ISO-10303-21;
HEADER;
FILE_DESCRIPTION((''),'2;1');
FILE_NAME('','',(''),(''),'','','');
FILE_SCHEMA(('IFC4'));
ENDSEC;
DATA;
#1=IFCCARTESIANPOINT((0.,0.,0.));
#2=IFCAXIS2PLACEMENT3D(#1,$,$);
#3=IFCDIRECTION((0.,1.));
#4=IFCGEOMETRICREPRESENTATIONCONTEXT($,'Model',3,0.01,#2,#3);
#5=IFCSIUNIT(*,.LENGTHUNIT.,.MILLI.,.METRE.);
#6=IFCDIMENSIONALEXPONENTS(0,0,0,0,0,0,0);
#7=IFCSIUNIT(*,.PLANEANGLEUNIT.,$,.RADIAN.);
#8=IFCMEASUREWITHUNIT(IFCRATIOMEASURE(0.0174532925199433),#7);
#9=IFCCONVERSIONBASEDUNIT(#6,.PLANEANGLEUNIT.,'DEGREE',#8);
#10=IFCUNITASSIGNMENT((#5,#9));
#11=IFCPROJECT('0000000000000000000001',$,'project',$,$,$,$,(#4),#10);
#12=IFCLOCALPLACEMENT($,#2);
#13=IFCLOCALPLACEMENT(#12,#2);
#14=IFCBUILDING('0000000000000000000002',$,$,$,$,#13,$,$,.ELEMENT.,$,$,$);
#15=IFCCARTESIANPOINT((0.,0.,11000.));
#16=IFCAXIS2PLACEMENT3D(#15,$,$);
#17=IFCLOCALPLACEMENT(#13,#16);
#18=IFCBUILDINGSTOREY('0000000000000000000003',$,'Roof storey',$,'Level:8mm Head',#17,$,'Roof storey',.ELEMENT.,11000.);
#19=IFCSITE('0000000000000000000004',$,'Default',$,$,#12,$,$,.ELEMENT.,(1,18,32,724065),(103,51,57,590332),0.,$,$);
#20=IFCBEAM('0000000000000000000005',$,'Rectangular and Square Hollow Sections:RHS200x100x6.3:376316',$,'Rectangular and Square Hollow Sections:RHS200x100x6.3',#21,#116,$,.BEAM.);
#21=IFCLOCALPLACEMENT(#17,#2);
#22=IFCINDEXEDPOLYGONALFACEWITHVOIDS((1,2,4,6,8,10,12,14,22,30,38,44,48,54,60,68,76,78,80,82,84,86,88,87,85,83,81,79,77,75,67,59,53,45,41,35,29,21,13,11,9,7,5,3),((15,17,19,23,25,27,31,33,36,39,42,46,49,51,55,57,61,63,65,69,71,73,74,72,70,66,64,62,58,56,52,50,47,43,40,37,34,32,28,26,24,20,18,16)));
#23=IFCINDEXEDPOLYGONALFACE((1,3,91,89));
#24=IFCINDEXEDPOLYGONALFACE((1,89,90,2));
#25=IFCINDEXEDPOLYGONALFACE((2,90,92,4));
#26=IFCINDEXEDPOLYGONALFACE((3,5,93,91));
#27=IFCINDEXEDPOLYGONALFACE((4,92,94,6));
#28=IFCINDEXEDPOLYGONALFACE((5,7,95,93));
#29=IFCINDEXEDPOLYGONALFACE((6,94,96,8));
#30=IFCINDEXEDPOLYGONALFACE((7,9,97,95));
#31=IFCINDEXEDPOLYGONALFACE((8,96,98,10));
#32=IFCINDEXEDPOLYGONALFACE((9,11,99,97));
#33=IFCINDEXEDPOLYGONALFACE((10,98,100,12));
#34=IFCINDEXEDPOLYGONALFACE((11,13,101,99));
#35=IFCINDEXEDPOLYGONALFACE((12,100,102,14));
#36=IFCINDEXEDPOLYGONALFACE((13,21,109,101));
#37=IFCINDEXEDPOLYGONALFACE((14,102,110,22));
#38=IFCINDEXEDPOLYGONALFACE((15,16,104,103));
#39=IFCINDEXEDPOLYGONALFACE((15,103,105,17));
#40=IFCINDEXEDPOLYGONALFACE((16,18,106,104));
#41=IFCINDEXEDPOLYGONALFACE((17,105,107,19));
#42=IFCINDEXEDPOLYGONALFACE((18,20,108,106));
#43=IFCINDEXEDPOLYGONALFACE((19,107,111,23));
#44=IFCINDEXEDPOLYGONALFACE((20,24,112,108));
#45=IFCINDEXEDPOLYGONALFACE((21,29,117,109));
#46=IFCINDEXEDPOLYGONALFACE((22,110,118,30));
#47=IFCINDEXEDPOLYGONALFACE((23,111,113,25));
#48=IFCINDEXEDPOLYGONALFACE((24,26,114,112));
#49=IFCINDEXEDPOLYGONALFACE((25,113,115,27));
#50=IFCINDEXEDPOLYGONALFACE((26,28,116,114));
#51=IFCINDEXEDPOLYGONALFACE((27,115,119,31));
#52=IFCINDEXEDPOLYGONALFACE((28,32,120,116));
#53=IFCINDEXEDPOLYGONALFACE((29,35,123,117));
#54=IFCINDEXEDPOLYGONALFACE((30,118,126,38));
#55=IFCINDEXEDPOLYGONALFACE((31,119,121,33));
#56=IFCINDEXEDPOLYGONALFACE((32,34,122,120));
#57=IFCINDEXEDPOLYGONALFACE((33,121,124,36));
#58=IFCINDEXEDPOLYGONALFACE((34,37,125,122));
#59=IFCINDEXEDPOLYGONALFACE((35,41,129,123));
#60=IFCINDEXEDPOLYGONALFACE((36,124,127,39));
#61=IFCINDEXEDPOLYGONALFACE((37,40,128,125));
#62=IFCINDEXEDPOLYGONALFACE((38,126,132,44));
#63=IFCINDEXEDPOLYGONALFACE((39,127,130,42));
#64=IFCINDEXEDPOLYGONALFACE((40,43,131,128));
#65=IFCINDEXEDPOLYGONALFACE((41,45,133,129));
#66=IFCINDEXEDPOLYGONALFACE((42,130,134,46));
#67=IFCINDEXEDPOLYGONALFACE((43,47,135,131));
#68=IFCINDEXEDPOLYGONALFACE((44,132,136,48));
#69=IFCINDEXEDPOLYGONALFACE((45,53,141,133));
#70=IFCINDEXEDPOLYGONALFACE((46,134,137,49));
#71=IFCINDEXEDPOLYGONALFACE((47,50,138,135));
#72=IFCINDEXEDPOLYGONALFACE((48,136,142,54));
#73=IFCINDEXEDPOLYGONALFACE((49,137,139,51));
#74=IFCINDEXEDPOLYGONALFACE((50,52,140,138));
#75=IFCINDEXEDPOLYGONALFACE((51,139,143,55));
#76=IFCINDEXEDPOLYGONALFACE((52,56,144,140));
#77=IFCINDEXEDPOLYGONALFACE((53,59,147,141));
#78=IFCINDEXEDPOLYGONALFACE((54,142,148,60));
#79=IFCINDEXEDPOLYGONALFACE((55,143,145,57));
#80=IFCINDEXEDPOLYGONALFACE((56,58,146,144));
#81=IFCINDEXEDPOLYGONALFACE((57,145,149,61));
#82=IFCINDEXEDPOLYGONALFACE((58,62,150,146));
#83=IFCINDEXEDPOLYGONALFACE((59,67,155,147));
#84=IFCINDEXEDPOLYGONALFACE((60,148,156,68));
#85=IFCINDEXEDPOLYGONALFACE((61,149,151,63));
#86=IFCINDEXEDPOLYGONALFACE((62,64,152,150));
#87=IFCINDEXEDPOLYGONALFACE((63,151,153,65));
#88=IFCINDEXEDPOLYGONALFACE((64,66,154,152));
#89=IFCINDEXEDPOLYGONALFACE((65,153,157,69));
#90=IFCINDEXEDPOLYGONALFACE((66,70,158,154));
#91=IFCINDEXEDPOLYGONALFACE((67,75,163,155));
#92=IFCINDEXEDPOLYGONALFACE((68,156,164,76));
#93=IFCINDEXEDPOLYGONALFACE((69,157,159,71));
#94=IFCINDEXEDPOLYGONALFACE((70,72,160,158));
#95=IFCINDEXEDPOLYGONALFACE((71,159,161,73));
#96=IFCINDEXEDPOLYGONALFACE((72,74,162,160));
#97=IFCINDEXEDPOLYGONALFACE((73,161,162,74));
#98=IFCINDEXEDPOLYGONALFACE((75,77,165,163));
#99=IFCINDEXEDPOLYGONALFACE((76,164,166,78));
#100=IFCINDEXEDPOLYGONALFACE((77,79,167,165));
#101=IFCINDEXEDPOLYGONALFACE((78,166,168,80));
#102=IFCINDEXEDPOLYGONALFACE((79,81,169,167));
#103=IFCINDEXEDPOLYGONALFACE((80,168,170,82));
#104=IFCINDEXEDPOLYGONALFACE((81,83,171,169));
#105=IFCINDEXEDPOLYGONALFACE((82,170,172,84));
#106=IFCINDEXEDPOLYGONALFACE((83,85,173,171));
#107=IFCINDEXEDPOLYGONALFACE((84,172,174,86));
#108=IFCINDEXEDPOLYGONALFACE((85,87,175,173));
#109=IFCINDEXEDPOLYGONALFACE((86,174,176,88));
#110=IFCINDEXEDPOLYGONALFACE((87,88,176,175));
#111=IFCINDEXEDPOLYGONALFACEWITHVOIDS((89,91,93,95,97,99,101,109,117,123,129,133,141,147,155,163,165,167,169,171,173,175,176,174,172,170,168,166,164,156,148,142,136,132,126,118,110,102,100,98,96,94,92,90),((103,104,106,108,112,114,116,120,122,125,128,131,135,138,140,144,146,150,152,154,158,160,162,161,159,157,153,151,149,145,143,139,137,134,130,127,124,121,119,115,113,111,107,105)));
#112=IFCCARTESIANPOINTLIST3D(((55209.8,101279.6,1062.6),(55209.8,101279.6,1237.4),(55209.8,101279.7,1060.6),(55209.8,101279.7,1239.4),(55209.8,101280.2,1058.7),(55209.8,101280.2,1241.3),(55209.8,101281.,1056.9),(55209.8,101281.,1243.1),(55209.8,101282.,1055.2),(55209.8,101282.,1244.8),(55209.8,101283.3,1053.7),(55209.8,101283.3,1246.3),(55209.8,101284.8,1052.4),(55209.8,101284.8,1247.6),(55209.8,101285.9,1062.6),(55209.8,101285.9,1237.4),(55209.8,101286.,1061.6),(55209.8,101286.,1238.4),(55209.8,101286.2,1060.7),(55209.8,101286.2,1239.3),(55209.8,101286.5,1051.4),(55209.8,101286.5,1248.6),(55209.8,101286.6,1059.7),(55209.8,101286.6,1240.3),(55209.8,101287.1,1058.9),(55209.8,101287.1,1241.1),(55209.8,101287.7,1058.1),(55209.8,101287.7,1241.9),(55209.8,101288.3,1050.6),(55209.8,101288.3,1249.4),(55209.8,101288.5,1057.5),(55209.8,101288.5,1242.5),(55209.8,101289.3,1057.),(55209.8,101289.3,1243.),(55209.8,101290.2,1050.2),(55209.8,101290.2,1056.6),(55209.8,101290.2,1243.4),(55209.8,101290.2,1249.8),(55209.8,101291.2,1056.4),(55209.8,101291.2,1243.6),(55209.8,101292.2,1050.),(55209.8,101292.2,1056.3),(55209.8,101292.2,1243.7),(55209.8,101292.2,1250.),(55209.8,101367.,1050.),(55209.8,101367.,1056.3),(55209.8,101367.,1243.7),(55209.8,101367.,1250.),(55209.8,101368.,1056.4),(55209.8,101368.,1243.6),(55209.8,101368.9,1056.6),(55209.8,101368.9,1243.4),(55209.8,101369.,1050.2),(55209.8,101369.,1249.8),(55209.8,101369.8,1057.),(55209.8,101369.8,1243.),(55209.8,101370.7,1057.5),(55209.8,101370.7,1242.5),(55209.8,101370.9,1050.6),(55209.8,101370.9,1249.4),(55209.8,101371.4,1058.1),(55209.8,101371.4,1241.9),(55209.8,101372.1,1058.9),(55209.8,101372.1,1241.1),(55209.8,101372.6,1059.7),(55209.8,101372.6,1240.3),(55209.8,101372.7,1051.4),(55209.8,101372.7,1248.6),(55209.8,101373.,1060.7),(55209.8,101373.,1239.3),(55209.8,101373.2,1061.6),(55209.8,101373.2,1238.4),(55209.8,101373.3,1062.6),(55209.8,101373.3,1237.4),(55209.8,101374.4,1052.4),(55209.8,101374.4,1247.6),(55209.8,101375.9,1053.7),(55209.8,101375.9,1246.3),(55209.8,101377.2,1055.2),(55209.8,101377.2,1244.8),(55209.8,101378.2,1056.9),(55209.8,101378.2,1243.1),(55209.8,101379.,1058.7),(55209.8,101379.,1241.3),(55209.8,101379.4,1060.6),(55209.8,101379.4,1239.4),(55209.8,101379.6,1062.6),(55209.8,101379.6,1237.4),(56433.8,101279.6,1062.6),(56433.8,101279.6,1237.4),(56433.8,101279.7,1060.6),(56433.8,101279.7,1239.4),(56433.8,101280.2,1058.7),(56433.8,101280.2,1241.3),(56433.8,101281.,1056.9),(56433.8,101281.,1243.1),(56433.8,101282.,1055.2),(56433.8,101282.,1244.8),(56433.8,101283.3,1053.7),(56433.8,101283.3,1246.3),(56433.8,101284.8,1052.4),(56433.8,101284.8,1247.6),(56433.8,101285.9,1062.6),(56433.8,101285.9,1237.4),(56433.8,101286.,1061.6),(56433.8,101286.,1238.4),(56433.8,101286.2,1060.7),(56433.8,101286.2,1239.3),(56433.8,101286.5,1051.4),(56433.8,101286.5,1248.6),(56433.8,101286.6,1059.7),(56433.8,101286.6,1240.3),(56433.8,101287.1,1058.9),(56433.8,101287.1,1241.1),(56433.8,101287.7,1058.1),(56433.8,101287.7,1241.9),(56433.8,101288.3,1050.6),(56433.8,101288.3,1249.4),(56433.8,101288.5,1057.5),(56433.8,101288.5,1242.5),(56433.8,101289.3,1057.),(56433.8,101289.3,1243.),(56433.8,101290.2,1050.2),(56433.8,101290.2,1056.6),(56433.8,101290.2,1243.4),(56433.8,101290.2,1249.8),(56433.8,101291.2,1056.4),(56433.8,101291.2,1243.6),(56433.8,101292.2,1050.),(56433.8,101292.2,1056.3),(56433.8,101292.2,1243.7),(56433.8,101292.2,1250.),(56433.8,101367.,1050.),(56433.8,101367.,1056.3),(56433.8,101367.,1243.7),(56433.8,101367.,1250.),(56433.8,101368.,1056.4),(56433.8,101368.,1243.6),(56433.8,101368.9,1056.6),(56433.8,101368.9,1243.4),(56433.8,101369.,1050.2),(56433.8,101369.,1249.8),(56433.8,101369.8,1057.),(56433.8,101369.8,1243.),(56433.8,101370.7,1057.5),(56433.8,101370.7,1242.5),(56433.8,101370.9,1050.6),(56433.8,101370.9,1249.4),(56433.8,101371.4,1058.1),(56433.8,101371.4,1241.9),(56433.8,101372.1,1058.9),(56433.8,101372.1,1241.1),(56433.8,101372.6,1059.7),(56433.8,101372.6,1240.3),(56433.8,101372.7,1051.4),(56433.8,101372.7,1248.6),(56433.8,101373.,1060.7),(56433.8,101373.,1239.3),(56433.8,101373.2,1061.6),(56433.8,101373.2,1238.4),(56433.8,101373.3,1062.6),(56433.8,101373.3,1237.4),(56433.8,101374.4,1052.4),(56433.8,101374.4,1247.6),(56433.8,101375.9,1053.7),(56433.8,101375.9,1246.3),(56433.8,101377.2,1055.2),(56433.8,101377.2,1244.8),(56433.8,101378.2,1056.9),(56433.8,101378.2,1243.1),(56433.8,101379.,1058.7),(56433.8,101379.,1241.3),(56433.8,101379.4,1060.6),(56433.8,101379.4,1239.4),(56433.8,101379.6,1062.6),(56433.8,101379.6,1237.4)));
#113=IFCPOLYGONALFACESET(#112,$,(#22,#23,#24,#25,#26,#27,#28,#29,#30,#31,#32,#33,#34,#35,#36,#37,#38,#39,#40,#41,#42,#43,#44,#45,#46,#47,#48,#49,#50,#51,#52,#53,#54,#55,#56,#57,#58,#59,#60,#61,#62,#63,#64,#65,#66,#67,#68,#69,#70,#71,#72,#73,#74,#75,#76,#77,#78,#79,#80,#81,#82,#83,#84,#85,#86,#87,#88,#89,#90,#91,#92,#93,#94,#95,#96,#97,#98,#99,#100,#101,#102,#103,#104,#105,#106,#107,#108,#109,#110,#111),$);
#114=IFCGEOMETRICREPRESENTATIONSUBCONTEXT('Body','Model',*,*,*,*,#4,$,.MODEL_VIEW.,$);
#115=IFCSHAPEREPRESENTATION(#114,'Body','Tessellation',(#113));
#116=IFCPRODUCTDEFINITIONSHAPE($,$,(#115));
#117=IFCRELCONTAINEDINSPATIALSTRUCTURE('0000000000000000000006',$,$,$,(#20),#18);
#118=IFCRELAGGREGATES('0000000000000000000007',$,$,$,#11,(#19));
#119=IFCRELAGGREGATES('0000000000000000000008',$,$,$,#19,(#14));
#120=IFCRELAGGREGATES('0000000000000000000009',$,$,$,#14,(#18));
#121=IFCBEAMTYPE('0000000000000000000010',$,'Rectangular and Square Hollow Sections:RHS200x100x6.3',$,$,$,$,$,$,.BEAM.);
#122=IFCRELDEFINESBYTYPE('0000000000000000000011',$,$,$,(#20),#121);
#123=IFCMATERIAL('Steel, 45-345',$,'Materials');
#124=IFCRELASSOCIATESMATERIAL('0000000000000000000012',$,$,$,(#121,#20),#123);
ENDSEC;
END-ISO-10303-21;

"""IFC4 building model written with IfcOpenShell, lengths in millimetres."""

from ifc_helpers import new_model, entity, si_unit, converted_unit, direction, frame, origin, place, context, subcontext, project, spatial, indexed_curve, outline, extrude, source, transform, mapped, material, type_object, type_shapes, element, save


model = new_model("IFC4")

# Units and contexts
model_context = context("Model", 3, precision=0.01, world=origin(), true_north=direction((0.0, 1.0)))
body_context = subcontext(model_context, "Body", "Model", "MODEL_VIEW")
ifc_project = project(units=[si_unit("LENGTHUNIT", "METRE", prefix="MILLI"), converted_unit("PLANEANGLEUNIT", "DEGREE", entity("IfcRatioMeasure", 0.0174532925199433), si_unit("PLANEANGLEUNIT", "RADIAN"), dimensions=[0, 0, 0, 0, 0, 0, 0])], contexts=[model_context])

# Site, building, storey
site_placement = place(None, origin())
site = spatial("IfcSite", under=ifc_project, at=site_placement, Name="Default", CompositionType="ELEMENT", RefLatitude=(1, 18, 32, 724065), RefLongitude=(103, 51, 57, 590332), RefElevation=0.0)
building_placement = place(site_placement, origin())
building = spatial("IfcBuilding", under=site, at=building_placement, CompositionType="ELEMENT")
storey_placement = place(building_placement, frame((0.0, 0.0, 11000.0)))
storey = spatial("IfcBuildingStorey", under=building, at=storey_placement, Name="Roof storey", ObjectType="Level:8mm Head", LongName="Roof storey", CompositionType="ELEMENT", Elevation=11000.0)

# Shared definitions
ifc_material = material(Name="Steel, 45-345", Category="Materials")

# Beam
beam_type_1 = type_object("IfcBeamType", Name="Rectangular and Square Hollow Sections:RHS200x100x6.3", PredefinedType="BEAM", material=ifc_material)
shared_shape_1 = source(origin(), body_context, "Body", "SweptSolid", [
    extrude(outline(indexed_curve([(87.4, -50.0), (89.4, -49.8), (91.3, -49.4), (93.1, -48.6), (94.8, -47.6), (96.3, -46.3), (97.6, -44.8), (98.6, -43.1), (99.4, -41.3), (99.8, -39.4), (100.0, -37.4), (100.0, 37.4), (99.8, 39.4), (99.4, 41.3), (98.6, 43.1), (97.6, 44.8), (96.3, 46.3), (94.8, 47.6), (93.1, 48.6), (91.3, 49.4), (89.4, 49.8), (87.4, 50.0), (-87.4, 50.0), (-89.4, 49.8), (-91.3, 49.4), (-93.1, 48.6), (-94.8, 47.6), (-96.3, 46.3), (-97.6, 44.8), (-98.6, 43.1), (-99.4, 41.3), (-99.8, 39.4), (-100.0, 37.4), (-100.0, -37.4), (-99.8, -39.4), (-99.4, -41.3), (-98.6, -43.1), (-97.6, -44.8), (-96.3, -46.3), (-94.8, -47.6), (-93.1, -48.6), (-91.3, -49.4), (-89.4, -49.8), (-87.4, -50.0), (87.4, -50.0)], self_intersect=False), holes=[indexed_curve([(93.7, 37.4), (93.7, -37.4), (93.6, -38.4), (93.4, -39.3), (93.0, -40.3), (92.5, -41.1), (91.9, -41.9), (91.1, -42.5), (90.3, -43.0), (89.3, -43.4), (88.4, -43.6), (87.4, -43.7), (-87.4, -43.7), (-88.4, -43.6), (-89.3, -43.4), (-90.3, -43.0), (-91.1, -42.5), (-91.9, -41.9), (-92.5, -41.1), (-93.0, -40.3), (-93.4, -39.3), (-93.6, -38.4), (-93.7, -37.4), (-93.7, 37.4), (-93.6, 38.4), (-93.4, 39.3), (-93.0, 40.3), (-92.5, 41.1), (-91.9, 41.9), (-91.1, 42.5), (-90.3, 43.0), (-89.3, 43.4), (-88.4, 43.6), (-87.4, 43.7), (87.4, 43.7), (88.4, 43.6), (89.3, 43.4), (90.3, 43.0), (91.1, 42.5), (91.9, 41.9), (92.5, 41.1), (93.0, 40.3), (93.4, 39.3), (93.6, 38.4), (93.7, 37.4)], self_intersect=False)]), frame((-612.0, 0.0, 0.0), z_axis=(1.0, 0.0, 0.0), x_axis=(0.0, 0.0, 1.0)), (0.0, 0.0, 1.0), 1224.0),
])
type_shapes(beam_type_1, [shared_shape_1])
beam_1_placement = place(storey_placement, frame((55821.8, 101329.6, 1150.0)))
element("IfcBeam", 1, at=beam_1_placement, inside=storey, type_object=beam_type_1, material=ifc_material, Name="Rectangular and Square Hollow Sections:RHS200x100x6.3:376316", ObjectType="Rectangular and Square Hollow Sections:RHS200x100x6.3", PredefinedType="BEAM", context=body_context, shape_type="MappedRepresentation", body=[
    mapped(shared_shape_1, transform((0.0, 0.0, 0.0), scale=1.0)),
])

save(model, "model.ifc")
